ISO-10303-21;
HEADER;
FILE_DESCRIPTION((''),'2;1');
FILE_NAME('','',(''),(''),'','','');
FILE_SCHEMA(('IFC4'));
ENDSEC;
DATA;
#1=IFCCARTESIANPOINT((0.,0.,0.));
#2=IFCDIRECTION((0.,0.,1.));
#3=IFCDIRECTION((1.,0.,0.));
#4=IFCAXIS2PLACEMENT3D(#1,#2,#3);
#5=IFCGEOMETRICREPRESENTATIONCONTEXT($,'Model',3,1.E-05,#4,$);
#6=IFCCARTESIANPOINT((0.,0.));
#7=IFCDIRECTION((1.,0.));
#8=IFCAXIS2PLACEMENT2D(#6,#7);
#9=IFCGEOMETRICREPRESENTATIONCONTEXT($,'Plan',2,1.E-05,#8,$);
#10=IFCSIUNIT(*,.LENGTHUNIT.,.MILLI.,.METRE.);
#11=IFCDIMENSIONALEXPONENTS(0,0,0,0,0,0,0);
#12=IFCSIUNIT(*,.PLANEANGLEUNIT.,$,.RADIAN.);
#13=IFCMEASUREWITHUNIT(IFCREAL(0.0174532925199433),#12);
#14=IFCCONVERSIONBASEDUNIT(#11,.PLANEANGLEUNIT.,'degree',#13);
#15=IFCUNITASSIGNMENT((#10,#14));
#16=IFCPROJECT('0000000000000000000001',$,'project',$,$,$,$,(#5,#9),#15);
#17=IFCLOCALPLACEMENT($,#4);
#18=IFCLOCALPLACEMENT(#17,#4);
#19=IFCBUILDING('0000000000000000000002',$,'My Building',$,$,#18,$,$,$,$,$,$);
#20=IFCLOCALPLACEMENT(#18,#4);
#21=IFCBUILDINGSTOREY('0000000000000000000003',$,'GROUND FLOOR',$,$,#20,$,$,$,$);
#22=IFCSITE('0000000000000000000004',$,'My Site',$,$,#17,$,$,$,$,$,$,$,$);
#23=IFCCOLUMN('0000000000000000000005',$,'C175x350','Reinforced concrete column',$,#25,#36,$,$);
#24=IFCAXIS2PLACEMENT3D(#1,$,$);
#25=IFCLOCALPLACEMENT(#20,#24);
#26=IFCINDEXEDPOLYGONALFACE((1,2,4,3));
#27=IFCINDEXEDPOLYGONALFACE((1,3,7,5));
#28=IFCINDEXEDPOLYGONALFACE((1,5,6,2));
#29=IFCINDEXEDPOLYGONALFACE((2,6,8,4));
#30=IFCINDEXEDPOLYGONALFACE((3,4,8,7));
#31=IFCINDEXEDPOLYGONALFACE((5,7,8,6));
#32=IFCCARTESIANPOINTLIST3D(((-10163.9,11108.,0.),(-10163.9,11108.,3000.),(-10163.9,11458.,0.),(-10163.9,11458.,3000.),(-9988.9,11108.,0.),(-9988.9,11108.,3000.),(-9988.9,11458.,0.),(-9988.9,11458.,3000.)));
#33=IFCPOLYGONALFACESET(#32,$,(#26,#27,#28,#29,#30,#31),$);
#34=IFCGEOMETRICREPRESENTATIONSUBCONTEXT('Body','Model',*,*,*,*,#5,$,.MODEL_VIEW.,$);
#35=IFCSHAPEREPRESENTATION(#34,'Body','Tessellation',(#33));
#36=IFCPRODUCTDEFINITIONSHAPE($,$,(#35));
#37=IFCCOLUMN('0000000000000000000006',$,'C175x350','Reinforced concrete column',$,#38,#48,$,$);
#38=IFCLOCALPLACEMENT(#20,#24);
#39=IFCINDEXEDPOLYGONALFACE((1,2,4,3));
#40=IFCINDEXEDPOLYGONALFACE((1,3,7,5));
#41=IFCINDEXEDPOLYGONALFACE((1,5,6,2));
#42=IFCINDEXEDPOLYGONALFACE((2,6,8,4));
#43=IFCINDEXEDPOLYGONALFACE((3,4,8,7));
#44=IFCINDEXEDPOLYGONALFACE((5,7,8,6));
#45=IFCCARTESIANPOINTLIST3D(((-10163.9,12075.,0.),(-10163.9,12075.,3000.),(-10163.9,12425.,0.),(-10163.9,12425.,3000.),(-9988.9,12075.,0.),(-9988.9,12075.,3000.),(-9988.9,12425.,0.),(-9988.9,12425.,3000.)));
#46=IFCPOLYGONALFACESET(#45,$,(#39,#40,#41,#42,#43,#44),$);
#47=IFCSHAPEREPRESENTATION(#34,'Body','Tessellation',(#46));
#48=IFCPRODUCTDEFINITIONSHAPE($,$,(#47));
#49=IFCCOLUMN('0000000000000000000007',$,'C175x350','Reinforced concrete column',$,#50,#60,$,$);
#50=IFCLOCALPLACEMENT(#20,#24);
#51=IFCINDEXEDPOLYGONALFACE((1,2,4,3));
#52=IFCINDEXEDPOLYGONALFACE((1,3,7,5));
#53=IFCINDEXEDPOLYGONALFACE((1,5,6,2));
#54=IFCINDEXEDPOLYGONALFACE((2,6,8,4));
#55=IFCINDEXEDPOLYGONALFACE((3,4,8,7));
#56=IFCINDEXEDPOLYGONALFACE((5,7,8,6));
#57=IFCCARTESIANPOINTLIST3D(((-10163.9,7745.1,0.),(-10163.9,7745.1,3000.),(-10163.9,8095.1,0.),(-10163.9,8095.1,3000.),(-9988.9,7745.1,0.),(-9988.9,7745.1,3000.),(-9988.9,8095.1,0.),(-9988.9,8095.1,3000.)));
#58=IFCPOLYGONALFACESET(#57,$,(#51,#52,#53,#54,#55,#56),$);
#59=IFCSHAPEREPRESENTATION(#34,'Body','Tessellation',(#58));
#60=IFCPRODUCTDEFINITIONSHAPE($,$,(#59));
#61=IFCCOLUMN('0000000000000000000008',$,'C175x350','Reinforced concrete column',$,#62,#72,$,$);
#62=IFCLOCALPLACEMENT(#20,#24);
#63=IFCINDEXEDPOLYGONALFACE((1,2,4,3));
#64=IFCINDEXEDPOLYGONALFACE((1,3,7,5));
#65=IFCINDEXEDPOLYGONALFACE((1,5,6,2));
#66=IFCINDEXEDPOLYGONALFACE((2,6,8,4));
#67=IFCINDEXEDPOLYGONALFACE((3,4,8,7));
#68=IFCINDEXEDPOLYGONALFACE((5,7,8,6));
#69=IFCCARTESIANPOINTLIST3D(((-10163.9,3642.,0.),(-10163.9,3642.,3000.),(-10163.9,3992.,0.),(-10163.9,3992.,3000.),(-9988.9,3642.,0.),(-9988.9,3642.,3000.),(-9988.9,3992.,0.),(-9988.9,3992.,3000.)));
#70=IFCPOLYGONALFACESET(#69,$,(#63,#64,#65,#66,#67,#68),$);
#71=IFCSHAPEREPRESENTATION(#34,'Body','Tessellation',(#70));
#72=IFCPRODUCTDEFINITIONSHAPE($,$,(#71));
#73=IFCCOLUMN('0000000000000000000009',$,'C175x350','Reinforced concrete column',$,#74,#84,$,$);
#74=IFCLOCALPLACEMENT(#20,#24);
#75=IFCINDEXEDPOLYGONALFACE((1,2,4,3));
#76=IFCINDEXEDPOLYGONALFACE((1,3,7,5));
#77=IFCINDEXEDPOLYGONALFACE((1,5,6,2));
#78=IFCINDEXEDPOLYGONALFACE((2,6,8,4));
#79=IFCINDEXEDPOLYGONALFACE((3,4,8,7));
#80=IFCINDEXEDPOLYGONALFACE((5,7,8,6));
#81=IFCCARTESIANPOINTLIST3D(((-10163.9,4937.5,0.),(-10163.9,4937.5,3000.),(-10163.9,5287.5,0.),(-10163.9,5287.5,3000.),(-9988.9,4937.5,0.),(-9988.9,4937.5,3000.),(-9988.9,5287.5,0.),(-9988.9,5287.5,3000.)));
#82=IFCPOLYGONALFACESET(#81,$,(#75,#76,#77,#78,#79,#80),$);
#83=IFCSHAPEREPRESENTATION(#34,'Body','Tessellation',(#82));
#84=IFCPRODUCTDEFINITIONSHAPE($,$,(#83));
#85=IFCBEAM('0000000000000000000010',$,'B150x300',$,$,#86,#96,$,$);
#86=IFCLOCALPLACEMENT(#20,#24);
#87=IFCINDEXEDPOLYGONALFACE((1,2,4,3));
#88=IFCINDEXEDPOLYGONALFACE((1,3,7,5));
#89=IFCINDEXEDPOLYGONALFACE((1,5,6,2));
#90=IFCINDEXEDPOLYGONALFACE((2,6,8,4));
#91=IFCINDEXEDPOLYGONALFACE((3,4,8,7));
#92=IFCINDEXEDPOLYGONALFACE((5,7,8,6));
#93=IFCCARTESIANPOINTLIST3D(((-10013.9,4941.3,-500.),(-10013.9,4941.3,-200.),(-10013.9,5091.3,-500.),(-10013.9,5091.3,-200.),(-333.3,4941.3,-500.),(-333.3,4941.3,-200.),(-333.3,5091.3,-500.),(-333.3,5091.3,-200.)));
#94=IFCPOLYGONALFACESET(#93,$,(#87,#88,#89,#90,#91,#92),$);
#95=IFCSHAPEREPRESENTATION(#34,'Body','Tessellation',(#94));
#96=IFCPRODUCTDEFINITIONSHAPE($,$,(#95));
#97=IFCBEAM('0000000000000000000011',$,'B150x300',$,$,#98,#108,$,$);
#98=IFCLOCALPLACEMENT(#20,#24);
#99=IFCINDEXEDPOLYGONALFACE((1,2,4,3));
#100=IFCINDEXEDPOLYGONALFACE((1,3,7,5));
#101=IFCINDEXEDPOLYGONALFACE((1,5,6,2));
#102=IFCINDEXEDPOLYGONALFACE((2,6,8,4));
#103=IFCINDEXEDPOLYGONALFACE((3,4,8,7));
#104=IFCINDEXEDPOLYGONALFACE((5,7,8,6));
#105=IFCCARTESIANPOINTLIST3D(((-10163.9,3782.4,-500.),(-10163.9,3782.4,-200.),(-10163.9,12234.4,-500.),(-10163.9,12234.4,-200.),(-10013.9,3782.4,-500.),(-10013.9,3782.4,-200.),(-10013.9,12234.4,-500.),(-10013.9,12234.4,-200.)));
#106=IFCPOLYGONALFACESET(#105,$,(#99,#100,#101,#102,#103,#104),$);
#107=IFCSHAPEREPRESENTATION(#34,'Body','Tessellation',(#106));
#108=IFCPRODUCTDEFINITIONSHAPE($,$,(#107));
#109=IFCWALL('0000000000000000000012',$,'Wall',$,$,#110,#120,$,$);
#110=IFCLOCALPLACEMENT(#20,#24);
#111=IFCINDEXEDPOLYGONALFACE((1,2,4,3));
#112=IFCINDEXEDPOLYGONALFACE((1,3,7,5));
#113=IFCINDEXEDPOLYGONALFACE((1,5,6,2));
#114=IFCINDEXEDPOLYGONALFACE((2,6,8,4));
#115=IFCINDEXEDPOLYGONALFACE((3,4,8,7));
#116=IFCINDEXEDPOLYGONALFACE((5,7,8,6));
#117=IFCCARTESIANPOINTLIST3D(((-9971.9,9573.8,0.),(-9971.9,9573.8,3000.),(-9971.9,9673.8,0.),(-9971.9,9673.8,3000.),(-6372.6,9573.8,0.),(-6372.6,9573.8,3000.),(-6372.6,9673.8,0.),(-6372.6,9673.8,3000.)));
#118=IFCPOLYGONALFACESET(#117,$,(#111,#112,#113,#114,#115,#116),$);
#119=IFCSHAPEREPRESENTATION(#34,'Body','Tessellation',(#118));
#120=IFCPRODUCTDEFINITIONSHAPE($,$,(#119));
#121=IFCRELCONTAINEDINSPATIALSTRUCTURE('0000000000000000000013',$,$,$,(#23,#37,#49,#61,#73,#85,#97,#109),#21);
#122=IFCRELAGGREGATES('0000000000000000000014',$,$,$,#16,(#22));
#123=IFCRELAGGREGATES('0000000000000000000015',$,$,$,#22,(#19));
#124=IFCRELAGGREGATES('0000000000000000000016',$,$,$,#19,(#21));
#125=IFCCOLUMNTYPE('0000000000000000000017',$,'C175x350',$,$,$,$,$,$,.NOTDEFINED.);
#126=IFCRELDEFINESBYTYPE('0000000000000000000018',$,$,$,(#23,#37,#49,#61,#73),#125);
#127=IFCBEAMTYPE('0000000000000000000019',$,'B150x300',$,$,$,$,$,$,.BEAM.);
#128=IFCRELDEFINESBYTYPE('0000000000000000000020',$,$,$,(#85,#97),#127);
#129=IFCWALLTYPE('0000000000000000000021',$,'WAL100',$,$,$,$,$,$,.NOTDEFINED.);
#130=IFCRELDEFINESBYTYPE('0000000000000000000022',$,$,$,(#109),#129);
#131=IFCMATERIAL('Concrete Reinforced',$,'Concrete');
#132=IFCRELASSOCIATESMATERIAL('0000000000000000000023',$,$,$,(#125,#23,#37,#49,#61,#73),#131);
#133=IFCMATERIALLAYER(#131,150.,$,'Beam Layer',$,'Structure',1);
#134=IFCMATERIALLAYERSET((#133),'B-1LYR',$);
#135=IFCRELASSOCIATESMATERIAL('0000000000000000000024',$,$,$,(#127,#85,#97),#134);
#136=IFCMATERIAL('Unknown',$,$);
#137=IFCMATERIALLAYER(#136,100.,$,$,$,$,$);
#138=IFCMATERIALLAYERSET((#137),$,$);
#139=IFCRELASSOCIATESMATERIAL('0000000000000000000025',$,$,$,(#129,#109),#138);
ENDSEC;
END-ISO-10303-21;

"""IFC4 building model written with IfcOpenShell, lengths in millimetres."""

from ifc_helpers import new_model, entity, si_unit, converted_unit, frame, origin_with_axes, origin_2d_with_axis, place, context, subcontext, project, spatial, indexed_curve, rectangle, outline, extrude, material, layer, layer_set, layer_usage, material_profile, profile_set, profile_usage, type_object, element, save


model = new_model("IFC4")

# Units and contexts
model_context = context("Model", 3, precision=1e-05, world=origin_with_axes())
plan_context = context("Plan", 2, precision=1e-05, world=origin_2d_with_axis())
body_context_1 = subcontext(model_context, "Body", "Model", "MODEL_VIEW")
ifc_project = project(units=[si_unit("LENGTHUNIT", "METRE", prefix="MILLI"), converted_unit("PLANEANGLEUNIT", "degree", entity("IfcReal", 0.0174532925199433), si_unit("PLANEANGLEUNIT", "RADIAN"), dimensions=[0, 0, 0, 0, 0, 0, 0])], contexts=[model_context, plan_context])

# Site, building, storey
site_placement = place(None, origin_with_axes())
site = spatial("IfcSite", under=ifc_project, at=site_placement, Name="My Site")
building_placement = place(site_placement, origin_with_axes())
building = spatial("IfcBuilding", under=site, at=building_placement, Name="My Building")
storey_placement = place(building_placement, origin_with_axes())
storey = spatial("IfcBuildingStorey", under=building, at=storey_placement, Name="GROUND FLOOR")

# Columns
ifc_material_1 = material(Name="Concrete Reinforced", Category="Concrete")
ifc_material_profile = material_profile(ifc_material_1, rectangle(XDim=175.0, YDim=350.0), Name="R. C. Layer", Category="Structure", Priority=1)
ifc_profile_set = profile_set([ifc_material_profile], Name="COL_1LYR")
ifc_profile_usage_1 = profile_usage(ifc_profile_set, cardinal=5)
column_type = type_object("IfcColumnType", Name="C175x350", PredefinedType="NOTDEFINED", material=ifc_profile_set)
column_1_placement = place(storey_placement, frame((-10076.4, 11283.0, 0.0), z_axis=(0.0, 0.0, 1.0), x_axis=(1.0, 0.0, 0.0)))
element("IfcColumn", 1, at=column_1_placement, inside=storey, type_object=column_type, material=ifc_profile_usage_1, Name="C175x350", Description="Reinforced concrete column", context=body_context_1, shape_type="SweptSolid", body=[
    extrude(rectangle(XDim=175.0, YDim=350.0), origin_with_axes(), (0.0, 0.0, 1.0), 3000.0),
])
ifc_profile_usage_2 = profile_usage(ifc_profile_set, cardinal=5)
column_2_placement = place(storey_placement, frame((-10076.4, 12250.0, 0.0), z_axis=(0.0, 0.0, 1.0), x_axis=(1.0, 0.0, 0.0)))
element("IfcColumn", 2, at=column_2_placement, inside=storey, type_object=column_type, material=ifc_profile_usage_2, Name="C175x350", Description="Reinforced concrete column", context=body_context_1, shape_type="SweptSolid", body=[
    extrude(rectangle(XDim=175.0, YDim=350.0), origin_with_axes(), (0.0, 0.0, 1.0), 3000.0),
])
ifc_profile_usage_3 = profile_usage(ifc_profile_set, cardinal=5)
column_3_placement = place(storey_placement, frame((-10076.4, 7920.1, 0.0), z_axis=(0.0, 0.0, 1.0), x_axis=(1.0, 0.0, 0.0)))
element("IfcColumn", 3, at=column_3_placement, inside=storey, type_object=column_type, material=ifc_profile_usage_3, Name="C175x350", Description="Reinforced concrete column", context=body_context_1, shape_type="SweptSolid", body=[
    extrude(rectangle(XDim=175.0, YDim=350.0), origin_with_axes(), (0.0, 0.0, 1.0), 3000.0),
])
ifc_profile_usage_4 = profile_usage(ifc_profile_set, cardinal=5)
column_4_placement = place(storey_placement, frame((-10076.4, 3817.0, 0.0), z_axis=(0.0, 0.0, 1.0), x_axis=(1.0, 0.0, 0.0)))
element("IfcColumn", 4, at=column_4_placement, inside=storey, type_object=column_type, material=ifc_profile_usage_4, Name="C175x350", Description="Reinforced concrete column", context=body_context_1, shape_type="SweptSolid", body=[
    extrude(rectangle(XDim=175.0, YDim=350.0), origin_with_axes(), (0.0, 0.0, 1.0), 3000.0),
])
ifc_profile_usage_5 = profile_usage(ifc_profile_set, cardinal=5)
column_5_placement = place(storey_placement, frame((-10076.4, 5112.5, 0.0), z_axis=(0.0, 0.0, 1.0), x_axis=(1.0, 0.0, 0.0)))
element("IfcColumn", 5, at=column_5_placement, inside=storey, type_object=column_type, material=ifc_profile_usage_5, Name="C175x350", Description="Reinforced concrete column", context=body_context_1, shape_type="SweptSolid", body=[
    extrude(rectangle(XDim=175.0, YDim=350.0), origin_with_axes(), (0.0, 0.0, 1.0), 3000.0),
])

# Beams
ifc_layer_1 = layer(ifc_material_1, 150.0, Name="Beam Layer", Category="Structure", Priority=1)
ifc_layer_set_1 = layer_set([ifc_layer_1], Name="B-1LYR")
ifc_layer_usage_1 = layer_usage(ifc_layer_set_1, "AXIS2", "POSITIVE", 0.0)
beam_type = type_object("IfcBeamType", Name="B150x300", PredefinedType="BEAM", material=ifc_layer_set_1)
beam_1_placement = place(storey_placement, frame((-10013.9, 4941.3, -500.0), z_axis=(0.0, 0.0, 1.0), x_axis=(1.0, 0.0, 0.0)))
element("IfcBeam", 6, at=beam_1_placement, inside=storey, type_object=beam_type, material=ifc_layer_usage_1, Name="B150x300", context=body_context_1, shape_type="SweptSolid", body=[
    extrude(outline(indexed_curve([(0.0, 0.0), (0.0, 150.0), (9680.7, 150.0), (9680.7, 0.0), (0.0, 0.0)], self_intersect=False)), origin_with_axes(), (0.0, 0.0, 1.0), 300.0),
])
ifc_layer_usage_2 = layer_usage(ifc_layer_set_1, "AXIS2", "POSITIVE", 0.0)
beam_2_placement = place(storey_placement, frame((-10163.9, 12234.4, -500.0), z_axis=(0.0, 0.0, 1.0), x_axis=(0.0, -1.0, 0.0)))
element("IfcBeam", 7, at=beam_2_placement, inside=storey, type_object=beam_type, material=ifc_layer_usage_2, Name="B150x300", context=body_context_1, shape_type="SweptSolid", body=[
    extrude(outline(indexed_curve([(0.0, 0.0), (0.0, 150.0), (8452.0, 150.0), (8452.0, 0.0), (0.0, 0.0)], self_intersect=False)), origin_with_axes(), (0.0, 0.0, 1.0), 300.0),
])

# Wall
ifc_material_2 = material(Name="Unknown")
ifc_layer_2 = layer(ifc_material_2, 100.0)
ifc_layer_set_2 = layer_set([ifc_layer_2])
ifc_layer_usage_3 = layer_usage(ifc_layer_set_2, "AXIS2", "POSITIVE", 0.0)
wall_type_1 = type_object("IfcWallType", Name="WAL100", PredefinedType="NOTDEFINED", material=ifc_layer_set_2)
wall_1_placement = place(storey_placement, frame((-9971.9, 9573.8, 0.0), z_axis=(0.0, 0.0, 1.0), x_axis=(1.0, 0.0, 0.0)))
element("IfcWall", 8, at=wall_1_placement, inside=storey, type_object=wall_type_1, material=ifc_layer_usage_3, Name="Wall", context=body_context_1, shape_type="SweptSolid", body=[
    extrude(outline(indexed_curve([(0.0, 0.0), (0.0, 100.0), (3599.3, 100.0), (3599.3, 0.0), (0.0, 0.0)], self_intersect=False)), origin_with_axes(), (0.0, 0.0, 1.0), 3000.0),
])

save(model, "model.ifc")
